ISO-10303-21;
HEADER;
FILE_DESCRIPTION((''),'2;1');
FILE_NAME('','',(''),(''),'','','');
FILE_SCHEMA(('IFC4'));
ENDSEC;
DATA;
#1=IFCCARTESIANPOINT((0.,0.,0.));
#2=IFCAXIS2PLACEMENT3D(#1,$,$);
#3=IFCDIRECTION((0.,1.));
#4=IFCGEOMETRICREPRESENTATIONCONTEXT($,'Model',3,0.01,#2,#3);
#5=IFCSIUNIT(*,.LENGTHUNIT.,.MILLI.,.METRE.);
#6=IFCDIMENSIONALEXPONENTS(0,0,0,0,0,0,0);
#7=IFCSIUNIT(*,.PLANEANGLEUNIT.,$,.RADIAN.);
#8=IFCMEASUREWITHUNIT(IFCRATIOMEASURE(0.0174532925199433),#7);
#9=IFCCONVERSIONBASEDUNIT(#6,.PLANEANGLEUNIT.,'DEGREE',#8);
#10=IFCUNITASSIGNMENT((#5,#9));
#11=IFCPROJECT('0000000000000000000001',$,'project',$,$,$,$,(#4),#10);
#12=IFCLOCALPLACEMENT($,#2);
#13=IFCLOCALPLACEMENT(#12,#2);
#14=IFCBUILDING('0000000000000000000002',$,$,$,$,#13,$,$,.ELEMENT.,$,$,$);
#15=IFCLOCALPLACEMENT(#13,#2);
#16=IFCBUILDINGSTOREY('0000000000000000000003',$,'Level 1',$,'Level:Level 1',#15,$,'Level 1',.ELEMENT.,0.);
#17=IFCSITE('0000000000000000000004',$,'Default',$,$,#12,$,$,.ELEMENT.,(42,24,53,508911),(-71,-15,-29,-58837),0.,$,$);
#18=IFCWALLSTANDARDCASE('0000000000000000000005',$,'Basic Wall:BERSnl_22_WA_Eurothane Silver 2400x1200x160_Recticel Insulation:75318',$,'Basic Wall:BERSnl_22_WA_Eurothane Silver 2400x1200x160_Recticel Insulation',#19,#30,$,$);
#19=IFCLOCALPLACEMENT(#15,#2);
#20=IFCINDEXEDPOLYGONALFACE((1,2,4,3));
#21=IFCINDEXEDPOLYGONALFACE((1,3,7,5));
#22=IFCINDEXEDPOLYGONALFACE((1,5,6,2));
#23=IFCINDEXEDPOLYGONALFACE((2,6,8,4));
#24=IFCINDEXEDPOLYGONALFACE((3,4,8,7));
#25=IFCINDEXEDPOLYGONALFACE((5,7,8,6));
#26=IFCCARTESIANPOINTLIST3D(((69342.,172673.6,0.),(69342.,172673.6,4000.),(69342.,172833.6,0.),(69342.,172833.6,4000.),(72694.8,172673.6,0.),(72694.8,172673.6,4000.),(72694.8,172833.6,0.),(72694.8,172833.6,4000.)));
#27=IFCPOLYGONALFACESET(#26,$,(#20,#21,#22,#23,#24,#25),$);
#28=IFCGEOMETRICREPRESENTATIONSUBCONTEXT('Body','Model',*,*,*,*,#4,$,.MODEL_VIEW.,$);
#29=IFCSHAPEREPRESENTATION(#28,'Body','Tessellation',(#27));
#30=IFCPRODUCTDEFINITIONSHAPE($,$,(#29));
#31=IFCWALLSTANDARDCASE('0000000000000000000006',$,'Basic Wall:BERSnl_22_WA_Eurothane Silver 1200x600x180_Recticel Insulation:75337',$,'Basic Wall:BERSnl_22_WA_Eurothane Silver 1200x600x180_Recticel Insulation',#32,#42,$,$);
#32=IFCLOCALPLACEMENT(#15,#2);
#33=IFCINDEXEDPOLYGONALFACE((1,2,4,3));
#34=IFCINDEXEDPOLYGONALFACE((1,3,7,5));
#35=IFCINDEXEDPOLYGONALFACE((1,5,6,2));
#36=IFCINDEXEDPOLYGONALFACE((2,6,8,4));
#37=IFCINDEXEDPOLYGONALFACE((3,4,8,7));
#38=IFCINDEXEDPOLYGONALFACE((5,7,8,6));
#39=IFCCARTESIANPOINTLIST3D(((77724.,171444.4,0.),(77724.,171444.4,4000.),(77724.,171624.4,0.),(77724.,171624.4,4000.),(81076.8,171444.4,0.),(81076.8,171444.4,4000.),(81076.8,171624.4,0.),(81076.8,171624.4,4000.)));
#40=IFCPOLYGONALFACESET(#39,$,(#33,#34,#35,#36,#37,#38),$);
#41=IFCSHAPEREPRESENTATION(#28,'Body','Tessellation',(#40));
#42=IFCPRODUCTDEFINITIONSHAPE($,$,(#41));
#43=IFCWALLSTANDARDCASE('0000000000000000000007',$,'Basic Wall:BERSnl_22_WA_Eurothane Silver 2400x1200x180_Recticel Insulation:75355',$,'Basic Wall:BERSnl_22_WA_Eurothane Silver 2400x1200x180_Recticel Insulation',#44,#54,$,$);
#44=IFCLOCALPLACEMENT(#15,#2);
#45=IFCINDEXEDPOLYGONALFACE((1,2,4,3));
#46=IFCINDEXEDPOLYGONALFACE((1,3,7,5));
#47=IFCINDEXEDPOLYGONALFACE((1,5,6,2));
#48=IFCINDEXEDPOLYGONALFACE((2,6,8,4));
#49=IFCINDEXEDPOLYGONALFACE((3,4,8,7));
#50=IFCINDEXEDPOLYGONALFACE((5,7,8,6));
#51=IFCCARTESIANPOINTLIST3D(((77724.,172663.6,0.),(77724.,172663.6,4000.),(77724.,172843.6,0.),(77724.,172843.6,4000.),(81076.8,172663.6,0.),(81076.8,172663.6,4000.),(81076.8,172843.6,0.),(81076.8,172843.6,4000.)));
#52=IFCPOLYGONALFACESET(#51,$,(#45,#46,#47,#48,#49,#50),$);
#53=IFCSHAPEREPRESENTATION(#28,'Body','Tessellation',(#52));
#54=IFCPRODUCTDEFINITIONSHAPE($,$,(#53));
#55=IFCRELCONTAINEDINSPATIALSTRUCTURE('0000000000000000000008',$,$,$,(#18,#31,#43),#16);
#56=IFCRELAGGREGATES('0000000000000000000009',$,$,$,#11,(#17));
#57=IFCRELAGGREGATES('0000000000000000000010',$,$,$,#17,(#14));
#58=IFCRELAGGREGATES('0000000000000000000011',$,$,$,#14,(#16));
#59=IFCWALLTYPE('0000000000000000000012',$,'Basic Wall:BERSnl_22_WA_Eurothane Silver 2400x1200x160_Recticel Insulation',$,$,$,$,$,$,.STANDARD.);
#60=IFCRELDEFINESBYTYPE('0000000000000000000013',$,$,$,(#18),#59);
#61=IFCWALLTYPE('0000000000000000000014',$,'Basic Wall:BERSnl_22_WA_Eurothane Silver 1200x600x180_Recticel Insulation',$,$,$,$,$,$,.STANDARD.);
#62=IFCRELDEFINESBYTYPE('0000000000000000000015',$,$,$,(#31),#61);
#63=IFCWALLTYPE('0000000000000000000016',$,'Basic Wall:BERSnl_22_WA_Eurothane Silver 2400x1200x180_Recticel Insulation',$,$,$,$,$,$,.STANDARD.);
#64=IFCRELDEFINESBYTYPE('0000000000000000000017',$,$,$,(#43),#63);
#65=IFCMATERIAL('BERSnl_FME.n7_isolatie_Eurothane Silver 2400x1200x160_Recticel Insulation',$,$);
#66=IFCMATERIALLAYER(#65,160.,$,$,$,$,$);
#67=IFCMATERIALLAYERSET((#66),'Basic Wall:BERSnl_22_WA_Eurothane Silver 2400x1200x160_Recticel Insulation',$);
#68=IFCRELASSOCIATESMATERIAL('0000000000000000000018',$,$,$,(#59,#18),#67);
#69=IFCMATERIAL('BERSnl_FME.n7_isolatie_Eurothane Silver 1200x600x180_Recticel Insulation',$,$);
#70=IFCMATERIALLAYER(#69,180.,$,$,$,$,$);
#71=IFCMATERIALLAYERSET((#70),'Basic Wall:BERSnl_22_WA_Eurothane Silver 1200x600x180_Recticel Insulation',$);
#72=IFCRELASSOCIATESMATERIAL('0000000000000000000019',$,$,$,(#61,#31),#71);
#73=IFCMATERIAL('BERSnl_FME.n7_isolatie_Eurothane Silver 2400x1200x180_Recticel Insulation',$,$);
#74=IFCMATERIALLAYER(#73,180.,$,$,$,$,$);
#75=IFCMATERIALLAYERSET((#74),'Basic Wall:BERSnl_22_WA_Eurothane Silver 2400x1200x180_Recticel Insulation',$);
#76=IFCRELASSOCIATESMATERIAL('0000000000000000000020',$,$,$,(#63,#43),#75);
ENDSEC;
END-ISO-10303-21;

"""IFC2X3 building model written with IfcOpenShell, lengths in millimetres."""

from ifc_helpers import new_model, entity, si_unit, converted_unit, direction, frame, frame_2d, origin, place, context, subcontext, project, spatial, rectangle, extrude, material, layer, layer_set, layer_usage, type_object, element, save


model = new_model("IFC2X3")

# Units and contexts
model_context = context("Model", 3, precision=0.01, world=origin(), true_north=direction((0.0, 1.0)))
body_context = subcontext(model_context, "Body", "Model", "MODEL_VIEW")
ifc_project = project(units=[si_unit("LENGTHUNIT", "METRE", prefix="MILLI"), converted_unit("PLANEANGLEUNIT", "DEGREE", entity("IfcRatioMeasure", 0.0174532925199433), si_unit("PLANEANGLEUNIT", "RADIAN"), dimensions=[0, 0, 0, 0, 0, 0, 0])], contexts=[model_context])

# Site, building, storey
site_placement = place(None, origin())
site = spatial("IfcSite", under=ifc_project, at=site_placement, Name="Default", CompositionType="ELEMENT", RefLatitude=(42, 24, 53, 508911), RefLongitude=(-71, -15, -29, -58837), RefElevation=0.0)
building_placement = place(site_placement, origin())
building = spatial("IfcBuilding", under=site, at=building_placement, CompositionType="ELEMENT")
storey_placement = place(building_placement, origin())
storey = spatial("IfcBuildingStorey", under=building, at=storey_placement, Name="Level 1", ObjectType="Level:Level 1", LongName="Level 1", CompositionType="ELEMENT", Elevation=0.0)

# Shared definitions
ifc_material_1 = material(Name="BERSnl_FME.n7_isolatie_Eurothane Silver 2400x1200x160_Recticel Insulation")
ifc_material_2 = material(Name="BERSnl_FME.n7_isolatie_Eurothane Silver 1200x600x180_Recticel Insulation")
ifc_material_3 = material(Name="BERSnl_FME.n7_isolatie_Eurothane Silver 2400x1200x180_Recticel Insulation")

# Walls
ifc_layer_1 = layer(ifc_material_1, 160.0)
ifc_layer_set_1 = layer_set([ifc_layer_1], Name="Basic Wall:BERSnl_22_WA_Eurothane Silver 2400x1200x160_Recticel Insulation")
ifc_layer_usage_1 = layer_usage(ifc_layer_set_1, "AXIS2", "NEGATIVE", 80.0)
wall_type_1 = type_object("IfcWallType", Name="Basic Wall:BERSnl_22_WA_Eurothane Silver 2400x1200x160_Recticel Insulation", PredefinedType="STANDARD", material=ifc_layer_set_1)
wall_1_placement = place(storey_placement, frame((69342.0, 172753.6, 0.0)))
element("IfcWallStandardCase", 1, at=wall_1_placement, inside=storey, type_object=wall_type_1, material=ifc_layer_usage_1, Name="Basic Wall:BERSnl_22_WA_Eurothane Silver 2400x1200x160_Recticel Insulation:75318", ObjectType="Basic Wall:BERSnl_22_WA_Eurothane Silver 2400x1200x160_Recticel Insulation", context=body_context, shape_type="SweptSolid", body=[
    extrude(rectangle(XDim=3352.8, YDim=160.0, at=frame_2d((1676.4, 0.0), x_axis=(-1.0, 0.0))), origin(), (0.0, 0.0, 1.0), 4000.0),
])
ifc_layer_2 = layer(ifc_material_2, 180.0)
ifc_layer_set_2 = layer_set([ifc_layer_2], Name="Basic Wall:BERSnl_22_WA_Eurothane Silver 1200x600x180_Recticel Insulation")
ifc_layer_usage_2 = layer_usage(ifc_layer_set_2, "AXIS2", "NEGATIVE", 90.0)
wall_type_2 = type_object("IfcWallType", Name="Basic Wall:BERSnl_22_WA_Eurothane Silver 1200x600x180_Recticel Insulation", PredefinedType="STANDARD", material=ifc_layer_set_2)
wall_2_placement = place(storey_placement, frame((77724.0, 171534.4, 0.0)))
element("IfcWallStandardCase", 2, at=wall_2_placement, inside=storey, type_object=wall_type_2, material=ifc_layer_usage_2, Name="Basic Wall:BERSnl_22_WA_Eurothane Silver 1200x600x180_Recticel Insulation:75337", ObjectType="Basic Wall:BERSnl_22_WA_Eurothane Silver 1200x600x180_Recticel Insulation", context=body_context, shape_type="SweptSolid", body=[
    extrude(rectangle(XDim=3352.8, YDim=180.0, at=frame_2d((1676.4, 0.0), x_axis=(-1.0, 0.0))), origin(), (0.0, 0.0, 1.0), 4000.0),
])
ifc_layer_3 = layer(ifc_material_3, 180.0)
ifc_layer_set_3 = layer_set([ifc_layer_3], Name="Basic Wall:BERSnl_22_WA_Eurothane Silver 2400x1200x180_Recticel Insulation")
ifc_layer_usage_3 = layer_usage(ifc_layer_set_3, "AXIS2", "NEGATIVE", 90.0)
wall_type_3 = type_object("IfcWallType", Name="Basic Wall:BERSnl_22_WA_Eurothane Silver 2400x1200x180_Recticel Insulation", PredefinedType="STANDARD", material=ifc_layer_set_3)
wall_3_placement = place(storey_placement, frame((77724.0, 172753.6, 0.0)))
element("IfcWallStandardCase", 3, at=wall_3_placement, inside=storey, type_object=wall_type_3, material=ifc_layer_usage_3, Name="Basic Wall:BERSnl_22_WA_Eurothane Silver 2400x1200x180_Recticel Insulation:75355", ObjectType="Basic Wall:BERSnl_22_WA_Eurothane Silver 2400x1200x180_Recticel Insulation", context=body_context, shape_type="SweptSolid", body=[
    extrude(rectangle(XDim=3352.8, YDim=180.0, at=frame_2d((1676.4, 0.0), x_axis=(-1.0, 0.0))), origin(), (0.0, 0.0, 1.0), 4000.0),
])

save(model, "model.ifc")
